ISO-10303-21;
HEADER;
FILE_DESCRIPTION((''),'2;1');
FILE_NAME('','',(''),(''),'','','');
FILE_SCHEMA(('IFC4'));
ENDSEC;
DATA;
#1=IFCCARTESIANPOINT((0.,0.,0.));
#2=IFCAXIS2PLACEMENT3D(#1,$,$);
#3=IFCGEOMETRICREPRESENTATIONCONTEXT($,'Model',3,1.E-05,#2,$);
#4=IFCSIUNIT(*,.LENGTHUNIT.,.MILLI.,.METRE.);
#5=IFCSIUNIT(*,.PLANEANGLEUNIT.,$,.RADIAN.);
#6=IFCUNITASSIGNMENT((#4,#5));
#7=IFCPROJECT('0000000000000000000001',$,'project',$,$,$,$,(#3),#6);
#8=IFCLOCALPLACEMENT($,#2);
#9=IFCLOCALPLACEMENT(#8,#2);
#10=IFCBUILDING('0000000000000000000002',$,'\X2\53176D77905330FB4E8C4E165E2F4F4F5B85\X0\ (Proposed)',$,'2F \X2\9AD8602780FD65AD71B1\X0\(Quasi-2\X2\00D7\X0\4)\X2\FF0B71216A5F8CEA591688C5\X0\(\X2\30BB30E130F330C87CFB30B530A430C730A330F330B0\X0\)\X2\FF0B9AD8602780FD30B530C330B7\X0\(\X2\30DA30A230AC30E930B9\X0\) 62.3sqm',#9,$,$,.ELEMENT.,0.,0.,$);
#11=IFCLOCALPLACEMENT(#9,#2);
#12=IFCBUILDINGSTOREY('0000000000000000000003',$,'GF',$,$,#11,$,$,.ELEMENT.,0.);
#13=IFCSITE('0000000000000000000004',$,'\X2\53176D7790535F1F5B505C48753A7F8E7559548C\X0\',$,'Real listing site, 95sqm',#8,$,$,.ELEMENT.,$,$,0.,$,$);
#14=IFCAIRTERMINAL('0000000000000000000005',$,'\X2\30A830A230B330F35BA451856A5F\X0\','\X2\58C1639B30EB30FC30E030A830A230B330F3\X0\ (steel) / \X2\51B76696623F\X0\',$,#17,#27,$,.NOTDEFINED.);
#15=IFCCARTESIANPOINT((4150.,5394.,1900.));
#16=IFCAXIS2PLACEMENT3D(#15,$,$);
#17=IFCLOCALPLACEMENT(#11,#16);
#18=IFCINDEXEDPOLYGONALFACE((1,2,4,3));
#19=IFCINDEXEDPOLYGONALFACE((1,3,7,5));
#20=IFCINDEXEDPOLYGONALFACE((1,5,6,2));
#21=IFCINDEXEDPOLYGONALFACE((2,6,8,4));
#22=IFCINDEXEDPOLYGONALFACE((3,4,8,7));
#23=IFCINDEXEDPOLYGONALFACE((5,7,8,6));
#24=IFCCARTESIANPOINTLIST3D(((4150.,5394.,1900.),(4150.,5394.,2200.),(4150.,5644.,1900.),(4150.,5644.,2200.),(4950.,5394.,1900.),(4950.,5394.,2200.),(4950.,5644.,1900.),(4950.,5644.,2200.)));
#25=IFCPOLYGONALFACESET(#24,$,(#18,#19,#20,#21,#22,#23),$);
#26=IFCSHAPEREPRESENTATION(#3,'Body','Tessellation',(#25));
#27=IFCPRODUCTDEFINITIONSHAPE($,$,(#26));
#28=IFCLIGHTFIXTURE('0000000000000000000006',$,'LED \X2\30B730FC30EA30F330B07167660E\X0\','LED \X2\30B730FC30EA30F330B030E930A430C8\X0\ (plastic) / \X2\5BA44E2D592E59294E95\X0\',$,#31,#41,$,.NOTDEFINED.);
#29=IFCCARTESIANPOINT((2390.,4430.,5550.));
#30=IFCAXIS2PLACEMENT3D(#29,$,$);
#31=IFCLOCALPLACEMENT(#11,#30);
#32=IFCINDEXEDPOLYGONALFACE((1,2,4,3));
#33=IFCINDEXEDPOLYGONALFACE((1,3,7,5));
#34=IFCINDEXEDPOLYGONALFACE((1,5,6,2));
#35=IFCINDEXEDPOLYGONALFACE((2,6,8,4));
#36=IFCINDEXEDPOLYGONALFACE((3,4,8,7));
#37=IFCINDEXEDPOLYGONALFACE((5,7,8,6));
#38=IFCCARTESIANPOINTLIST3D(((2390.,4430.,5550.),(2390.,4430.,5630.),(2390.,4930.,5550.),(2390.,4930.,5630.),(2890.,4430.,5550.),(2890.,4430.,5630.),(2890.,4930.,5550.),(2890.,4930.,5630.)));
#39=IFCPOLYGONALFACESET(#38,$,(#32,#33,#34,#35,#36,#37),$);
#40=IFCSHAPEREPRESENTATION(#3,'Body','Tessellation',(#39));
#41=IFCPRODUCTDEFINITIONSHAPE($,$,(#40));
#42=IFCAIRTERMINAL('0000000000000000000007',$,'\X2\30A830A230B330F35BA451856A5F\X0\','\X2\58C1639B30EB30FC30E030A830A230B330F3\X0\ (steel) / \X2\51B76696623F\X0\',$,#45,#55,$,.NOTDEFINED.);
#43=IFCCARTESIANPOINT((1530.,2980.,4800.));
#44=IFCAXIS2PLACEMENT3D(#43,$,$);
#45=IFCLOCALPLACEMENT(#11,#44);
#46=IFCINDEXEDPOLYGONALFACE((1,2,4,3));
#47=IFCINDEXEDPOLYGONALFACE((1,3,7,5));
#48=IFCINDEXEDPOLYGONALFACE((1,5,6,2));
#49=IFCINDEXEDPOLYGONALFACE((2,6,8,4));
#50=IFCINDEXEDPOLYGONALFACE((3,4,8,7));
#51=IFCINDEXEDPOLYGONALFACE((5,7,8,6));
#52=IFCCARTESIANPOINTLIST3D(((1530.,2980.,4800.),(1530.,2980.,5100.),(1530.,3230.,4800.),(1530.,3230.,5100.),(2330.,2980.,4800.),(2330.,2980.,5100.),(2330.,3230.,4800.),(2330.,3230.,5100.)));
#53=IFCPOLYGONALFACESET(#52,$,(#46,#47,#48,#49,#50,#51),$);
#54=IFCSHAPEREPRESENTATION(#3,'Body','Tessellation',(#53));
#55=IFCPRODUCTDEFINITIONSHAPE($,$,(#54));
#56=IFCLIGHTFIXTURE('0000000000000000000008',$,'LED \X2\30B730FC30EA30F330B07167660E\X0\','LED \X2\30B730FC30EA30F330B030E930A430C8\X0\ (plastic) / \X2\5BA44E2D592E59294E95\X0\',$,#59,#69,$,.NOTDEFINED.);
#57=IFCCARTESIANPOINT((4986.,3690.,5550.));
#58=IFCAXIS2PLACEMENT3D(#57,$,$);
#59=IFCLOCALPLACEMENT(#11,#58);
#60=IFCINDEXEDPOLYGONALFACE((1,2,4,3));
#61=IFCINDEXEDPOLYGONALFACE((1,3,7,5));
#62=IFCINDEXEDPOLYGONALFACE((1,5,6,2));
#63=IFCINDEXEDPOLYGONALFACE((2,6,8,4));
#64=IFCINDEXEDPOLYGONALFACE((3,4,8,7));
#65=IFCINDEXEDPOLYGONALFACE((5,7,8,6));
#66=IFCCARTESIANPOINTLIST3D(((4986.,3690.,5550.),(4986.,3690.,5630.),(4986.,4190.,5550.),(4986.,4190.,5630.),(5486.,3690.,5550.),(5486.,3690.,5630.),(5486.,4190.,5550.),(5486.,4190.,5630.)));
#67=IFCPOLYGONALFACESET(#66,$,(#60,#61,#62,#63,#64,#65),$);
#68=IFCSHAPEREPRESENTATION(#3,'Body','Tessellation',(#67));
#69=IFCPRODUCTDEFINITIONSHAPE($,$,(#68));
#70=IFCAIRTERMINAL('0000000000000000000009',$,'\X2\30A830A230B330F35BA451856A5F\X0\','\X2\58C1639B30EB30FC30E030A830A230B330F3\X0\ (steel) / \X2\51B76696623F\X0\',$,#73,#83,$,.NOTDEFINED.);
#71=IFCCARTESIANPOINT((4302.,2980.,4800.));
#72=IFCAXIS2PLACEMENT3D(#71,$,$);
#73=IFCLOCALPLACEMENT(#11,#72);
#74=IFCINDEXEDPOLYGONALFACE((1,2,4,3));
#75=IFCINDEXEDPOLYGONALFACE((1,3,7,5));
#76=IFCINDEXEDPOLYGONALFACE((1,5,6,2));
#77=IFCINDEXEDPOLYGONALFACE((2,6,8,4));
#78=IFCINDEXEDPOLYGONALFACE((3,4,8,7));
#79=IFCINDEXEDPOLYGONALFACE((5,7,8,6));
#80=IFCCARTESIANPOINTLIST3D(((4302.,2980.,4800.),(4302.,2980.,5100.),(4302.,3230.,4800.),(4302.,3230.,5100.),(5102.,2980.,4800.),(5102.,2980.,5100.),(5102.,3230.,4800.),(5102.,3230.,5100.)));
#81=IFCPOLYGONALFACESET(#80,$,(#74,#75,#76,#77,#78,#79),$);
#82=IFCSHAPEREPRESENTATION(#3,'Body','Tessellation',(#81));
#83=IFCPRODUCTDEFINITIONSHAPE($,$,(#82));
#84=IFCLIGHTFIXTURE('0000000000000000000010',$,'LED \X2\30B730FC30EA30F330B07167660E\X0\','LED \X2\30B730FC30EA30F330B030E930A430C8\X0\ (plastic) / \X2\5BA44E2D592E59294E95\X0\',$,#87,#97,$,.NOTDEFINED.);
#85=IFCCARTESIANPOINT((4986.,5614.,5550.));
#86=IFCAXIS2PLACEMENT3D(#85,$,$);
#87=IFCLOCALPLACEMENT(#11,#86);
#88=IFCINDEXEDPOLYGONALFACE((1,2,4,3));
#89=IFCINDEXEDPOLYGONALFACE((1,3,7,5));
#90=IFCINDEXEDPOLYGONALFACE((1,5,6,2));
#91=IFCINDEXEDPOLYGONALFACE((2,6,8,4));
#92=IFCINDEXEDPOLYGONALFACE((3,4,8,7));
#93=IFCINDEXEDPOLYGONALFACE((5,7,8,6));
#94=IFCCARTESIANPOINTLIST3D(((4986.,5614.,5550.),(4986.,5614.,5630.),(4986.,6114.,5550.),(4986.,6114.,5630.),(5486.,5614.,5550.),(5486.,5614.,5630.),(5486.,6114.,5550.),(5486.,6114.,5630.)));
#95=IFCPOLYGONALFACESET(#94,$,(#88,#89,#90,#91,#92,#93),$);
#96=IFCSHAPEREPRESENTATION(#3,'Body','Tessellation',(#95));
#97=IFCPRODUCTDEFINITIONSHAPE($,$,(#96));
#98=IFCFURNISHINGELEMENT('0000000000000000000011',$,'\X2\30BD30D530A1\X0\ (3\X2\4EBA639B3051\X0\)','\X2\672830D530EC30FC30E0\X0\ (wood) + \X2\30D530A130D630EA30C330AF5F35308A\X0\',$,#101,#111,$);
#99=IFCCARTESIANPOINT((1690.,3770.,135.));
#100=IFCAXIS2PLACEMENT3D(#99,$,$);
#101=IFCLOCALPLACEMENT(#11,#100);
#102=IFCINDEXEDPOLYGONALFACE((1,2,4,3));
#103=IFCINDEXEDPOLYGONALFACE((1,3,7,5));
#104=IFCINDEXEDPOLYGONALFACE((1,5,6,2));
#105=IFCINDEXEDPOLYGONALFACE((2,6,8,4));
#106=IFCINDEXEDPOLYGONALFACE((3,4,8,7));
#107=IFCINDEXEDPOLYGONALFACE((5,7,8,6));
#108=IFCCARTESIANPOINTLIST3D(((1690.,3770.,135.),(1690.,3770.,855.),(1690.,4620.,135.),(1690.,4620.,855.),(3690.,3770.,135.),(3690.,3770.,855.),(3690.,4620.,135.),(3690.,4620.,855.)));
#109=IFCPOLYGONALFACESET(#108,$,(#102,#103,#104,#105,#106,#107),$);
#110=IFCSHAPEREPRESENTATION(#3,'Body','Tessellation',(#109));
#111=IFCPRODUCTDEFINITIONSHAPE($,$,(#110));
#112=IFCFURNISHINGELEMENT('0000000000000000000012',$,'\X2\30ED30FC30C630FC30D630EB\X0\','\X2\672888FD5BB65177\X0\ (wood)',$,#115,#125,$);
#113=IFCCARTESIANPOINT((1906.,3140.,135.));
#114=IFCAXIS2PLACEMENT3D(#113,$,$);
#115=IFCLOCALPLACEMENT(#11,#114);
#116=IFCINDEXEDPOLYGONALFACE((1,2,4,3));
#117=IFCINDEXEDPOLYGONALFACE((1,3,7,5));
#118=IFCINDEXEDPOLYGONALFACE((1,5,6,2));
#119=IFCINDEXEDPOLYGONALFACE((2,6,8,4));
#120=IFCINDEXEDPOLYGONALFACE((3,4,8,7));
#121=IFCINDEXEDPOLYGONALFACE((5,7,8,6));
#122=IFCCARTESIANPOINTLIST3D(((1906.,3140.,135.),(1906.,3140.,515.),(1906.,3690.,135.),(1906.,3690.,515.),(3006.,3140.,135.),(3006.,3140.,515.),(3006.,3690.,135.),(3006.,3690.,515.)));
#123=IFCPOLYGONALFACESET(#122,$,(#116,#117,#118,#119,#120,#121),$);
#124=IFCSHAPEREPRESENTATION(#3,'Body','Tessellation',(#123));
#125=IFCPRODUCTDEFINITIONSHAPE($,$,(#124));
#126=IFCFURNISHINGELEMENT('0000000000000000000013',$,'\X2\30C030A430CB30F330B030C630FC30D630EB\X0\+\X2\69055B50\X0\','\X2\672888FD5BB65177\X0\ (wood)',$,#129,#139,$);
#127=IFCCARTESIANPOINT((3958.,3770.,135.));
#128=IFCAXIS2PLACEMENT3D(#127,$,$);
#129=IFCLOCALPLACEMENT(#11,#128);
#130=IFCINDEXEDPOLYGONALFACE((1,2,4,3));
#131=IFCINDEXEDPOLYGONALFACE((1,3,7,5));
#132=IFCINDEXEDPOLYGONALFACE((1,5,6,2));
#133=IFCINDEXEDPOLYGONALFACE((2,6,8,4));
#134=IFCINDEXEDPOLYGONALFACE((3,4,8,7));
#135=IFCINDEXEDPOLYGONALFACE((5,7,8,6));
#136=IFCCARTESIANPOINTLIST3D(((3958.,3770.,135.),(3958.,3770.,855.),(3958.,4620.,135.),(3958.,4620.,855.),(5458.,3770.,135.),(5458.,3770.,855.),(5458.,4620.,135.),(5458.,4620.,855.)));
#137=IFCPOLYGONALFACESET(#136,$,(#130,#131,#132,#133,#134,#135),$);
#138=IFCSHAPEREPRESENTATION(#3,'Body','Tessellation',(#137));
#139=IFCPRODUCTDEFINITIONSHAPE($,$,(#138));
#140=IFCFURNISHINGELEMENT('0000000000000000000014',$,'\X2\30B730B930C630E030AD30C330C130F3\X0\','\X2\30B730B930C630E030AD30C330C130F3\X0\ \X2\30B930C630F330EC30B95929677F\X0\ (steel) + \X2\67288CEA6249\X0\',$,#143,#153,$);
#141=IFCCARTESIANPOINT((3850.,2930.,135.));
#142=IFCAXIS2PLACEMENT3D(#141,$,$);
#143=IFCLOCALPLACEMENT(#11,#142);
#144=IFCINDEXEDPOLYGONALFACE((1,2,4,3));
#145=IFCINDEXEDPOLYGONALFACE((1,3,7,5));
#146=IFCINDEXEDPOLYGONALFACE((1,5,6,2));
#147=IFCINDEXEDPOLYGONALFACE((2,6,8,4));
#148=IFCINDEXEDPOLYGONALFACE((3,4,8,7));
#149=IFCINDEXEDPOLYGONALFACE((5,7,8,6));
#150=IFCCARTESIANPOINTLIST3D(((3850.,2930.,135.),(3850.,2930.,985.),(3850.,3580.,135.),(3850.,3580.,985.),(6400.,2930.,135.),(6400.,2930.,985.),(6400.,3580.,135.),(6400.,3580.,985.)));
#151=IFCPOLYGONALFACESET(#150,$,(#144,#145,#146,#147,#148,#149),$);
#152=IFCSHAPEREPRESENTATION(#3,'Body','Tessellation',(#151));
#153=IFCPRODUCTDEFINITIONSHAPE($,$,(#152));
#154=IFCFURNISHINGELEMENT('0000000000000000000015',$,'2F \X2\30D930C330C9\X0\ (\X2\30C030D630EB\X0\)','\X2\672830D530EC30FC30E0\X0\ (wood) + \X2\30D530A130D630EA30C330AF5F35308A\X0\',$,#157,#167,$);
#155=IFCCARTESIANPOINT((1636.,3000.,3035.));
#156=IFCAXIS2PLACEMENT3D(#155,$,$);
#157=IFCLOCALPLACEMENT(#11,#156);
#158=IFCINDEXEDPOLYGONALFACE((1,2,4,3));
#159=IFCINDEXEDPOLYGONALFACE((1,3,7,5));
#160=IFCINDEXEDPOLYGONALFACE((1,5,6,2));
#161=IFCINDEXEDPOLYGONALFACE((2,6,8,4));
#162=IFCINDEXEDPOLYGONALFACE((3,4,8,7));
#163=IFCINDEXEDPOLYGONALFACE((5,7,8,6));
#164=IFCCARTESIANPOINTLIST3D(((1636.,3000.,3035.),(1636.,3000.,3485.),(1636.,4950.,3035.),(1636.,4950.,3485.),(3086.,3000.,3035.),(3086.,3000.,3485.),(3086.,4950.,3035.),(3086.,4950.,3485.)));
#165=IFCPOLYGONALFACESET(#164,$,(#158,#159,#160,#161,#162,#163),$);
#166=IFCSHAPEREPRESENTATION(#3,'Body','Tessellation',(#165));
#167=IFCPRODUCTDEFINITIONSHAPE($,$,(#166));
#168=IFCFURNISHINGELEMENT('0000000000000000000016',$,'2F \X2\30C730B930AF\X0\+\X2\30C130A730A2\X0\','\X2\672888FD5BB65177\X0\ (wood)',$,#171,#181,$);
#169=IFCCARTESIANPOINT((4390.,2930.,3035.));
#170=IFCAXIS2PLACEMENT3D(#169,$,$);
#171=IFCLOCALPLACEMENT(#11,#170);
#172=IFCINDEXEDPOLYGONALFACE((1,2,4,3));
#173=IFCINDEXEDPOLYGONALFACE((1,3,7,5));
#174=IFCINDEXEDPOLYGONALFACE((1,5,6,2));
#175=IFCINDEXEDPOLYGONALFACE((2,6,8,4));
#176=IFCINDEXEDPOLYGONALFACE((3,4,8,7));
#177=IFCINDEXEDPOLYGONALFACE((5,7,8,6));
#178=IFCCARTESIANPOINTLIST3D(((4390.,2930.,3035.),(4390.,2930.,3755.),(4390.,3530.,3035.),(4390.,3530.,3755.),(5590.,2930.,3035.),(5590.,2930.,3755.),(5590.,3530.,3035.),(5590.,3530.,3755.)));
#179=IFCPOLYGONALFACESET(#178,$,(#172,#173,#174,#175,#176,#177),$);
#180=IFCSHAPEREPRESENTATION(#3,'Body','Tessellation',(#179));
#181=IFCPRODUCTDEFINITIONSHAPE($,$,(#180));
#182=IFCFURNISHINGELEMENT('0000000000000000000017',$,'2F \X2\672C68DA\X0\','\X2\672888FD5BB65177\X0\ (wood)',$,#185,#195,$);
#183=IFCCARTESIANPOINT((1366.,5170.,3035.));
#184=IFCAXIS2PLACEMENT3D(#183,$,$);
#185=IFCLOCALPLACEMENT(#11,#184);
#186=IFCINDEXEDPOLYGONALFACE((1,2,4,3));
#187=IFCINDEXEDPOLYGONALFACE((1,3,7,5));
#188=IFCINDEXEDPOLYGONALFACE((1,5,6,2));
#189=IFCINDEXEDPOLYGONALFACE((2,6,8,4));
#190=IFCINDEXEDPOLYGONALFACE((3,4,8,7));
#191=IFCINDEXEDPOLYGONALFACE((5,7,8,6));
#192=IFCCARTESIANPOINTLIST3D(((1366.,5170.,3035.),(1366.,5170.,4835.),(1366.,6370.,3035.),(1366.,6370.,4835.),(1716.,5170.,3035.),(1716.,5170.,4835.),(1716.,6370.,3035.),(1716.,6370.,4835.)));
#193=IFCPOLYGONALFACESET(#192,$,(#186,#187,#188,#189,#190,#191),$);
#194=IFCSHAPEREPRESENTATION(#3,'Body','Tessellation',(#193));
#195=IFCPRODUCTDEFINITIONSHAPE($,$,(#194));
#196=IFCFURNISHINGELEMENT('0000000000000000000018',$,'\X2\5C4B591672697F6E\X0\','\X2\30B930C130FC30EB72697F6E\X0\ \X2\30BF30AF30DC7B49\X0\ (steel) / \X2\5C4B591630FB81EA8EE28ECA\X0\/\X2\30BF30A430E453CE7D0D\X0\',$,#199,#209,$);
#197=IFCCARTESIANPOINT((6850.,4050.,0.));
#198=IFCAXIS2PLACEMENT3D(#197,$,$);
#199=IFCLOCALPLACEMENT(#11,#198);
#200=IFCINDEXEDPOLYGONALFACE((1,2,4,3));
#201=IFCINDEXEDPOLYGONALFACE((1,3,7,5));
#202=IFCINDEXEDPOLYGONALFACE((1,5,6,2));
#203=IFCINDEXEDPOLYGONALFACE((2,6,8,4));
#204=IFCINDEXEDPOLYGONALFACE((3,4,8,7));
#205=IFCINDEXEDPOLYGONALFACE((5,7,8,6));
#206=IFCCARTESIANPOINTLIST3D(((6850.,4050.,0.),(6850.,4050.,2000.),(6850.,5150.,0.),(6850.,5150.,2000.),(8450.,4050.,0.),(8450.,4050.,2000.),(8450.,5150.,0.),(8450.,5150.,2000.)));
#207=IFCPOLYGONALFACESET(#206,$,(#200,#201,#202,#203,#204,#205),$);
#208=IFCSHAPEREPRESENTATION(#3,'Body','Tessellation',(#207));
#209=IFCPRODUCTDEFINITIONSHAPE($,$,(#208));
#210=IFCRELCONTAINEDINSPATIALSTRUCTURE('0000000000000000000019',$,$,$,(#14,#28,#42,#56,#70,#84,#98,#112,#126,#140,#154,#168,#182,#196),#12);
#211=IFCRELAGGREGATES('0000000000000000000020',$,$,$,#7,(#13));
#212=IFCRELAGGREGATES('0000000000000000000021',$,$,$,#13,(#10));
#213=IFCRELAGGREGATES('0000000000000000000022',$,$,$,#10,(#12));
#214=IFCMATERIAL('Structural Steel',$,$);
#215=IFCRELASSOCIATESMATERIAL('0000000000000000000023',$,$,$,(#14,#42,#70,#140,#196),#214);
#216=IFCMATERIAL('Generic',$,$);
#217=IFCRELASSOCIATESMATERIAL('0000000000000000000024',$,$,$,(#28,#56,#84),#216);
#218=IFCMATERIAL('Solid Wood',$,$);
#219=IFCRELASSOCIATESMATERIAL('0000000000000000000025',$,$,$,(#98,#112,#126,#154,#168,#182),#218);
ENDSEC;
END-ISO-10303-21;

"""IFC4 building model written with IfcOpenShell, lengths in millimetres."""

from ifc_helpers import new_model, si_unit, frame, frame_2d, origin, place, context, project, spatial, rectangle, extrude, material, element, save


model = new_model("IFC4")

# Units and contexts
model_context = context("Model", 3, precision=1e-05, world=origin())
ifc_project = project(units=[si_unit("LENGTHUNIT", "METRE", prefix="MILLI"), si_unit("PLANEANGLEUNIT", "RADIAN")], contexts=[model_context])

# Site, building, storey
site_placement = place(None, origin())
site = spatial("IfcSite", under=ifc_project, at=site_placement, Name="北海道弟子屈町美留和", ObjectType="Real listing site, 95sqm", CompositionType="ELEMENT", RefElevation=0.0)
building_placement = place(site_placement, origin())
building = spatial("IfcBuilding", under=site, at=building_placement, Name="北海道・二世帯住宅 (Proposed)", ObjectType="2F 高性能断熱(Quasi-2×4)＋無機質外装(セメント系サイディング)＋高性能サッシ(ペアガラス) 62.3sqm", CompositionType="ELEMENT", ElevationOfRefHeight=0.0, ElevationOfTerrain=0.0)
storey_placement = place(building_placement, origin())
storey = spatial("IfcBuildingStorey", under=building, at=storey_placement, Name="GF", CompositionType="ELEMENT", Elevation=0.0)

# Shared definitions
ifc_material_1 = material(Name="Solid Wood")

# Shared definitions
ifc_material_2 = material(Name="Structural Steel")

# Shared definitions
ifc_material_3 = material(Name="Generic")

# Air terminal
air_terminal_1_placement = place(storey_placement, frame((4150.0, 5394.0, 1900.0)))
element("IfcAirTerminal", 1, at=air_terminal_1_placement, inside=storey, material=ifc_material_2, Name="エアコン室内機", Description="壁掛ルームエアコン (steel) / 冷暖房", PredefinedType="NOTDEFINED", context=model_context, shape_type="SweptSolid", body=[
    extrude(rectangle(XDim=800.0, YDim=250.0, at=frame_2d((400.0, 125.0))), frame((4150.0, 5394.0, 1900.0)), (0.0, 0.0, 1.0), 300.0),
])

# Light fixture
light_fixture_1_placement = place(storey_placement, frame((2390.0, 4430.0, 5550.0)))
element("IfcLightFixture", 2, at=light_fixture_1_placement, inside=storey, material=ifc_material_3, Name="LED シーリング照明", Description="LED シーリングライト (plastic) / 室中央天井", PredefinedType="NOTDEFINED", context=model_context, shape_type="SweptSolid", body=[
    extrude(rectangle(XDim=500.0, YDim=500.0, at=frame_2d((250.0, 250.0))), frame((2390.0, 4430.0, 5550.0)), (0.0, 0.0, 1.0), 80.0),
])

# Air terminal
air_terminal_2_placement = place(storey_placement, frame((1530.0, 2980.0, 4800.0)))
element("IfcAirTerminal", 3, at=air_terminal_2_placement, inside=storey, material=ifc_material_2, Name="エアコン室内機", Description="壁掛ルームエアコン (steel) / 冷暖房", PredefinedType="NOTDEFINED", context=model_context, shape_type="SweptSolid", body=[
    extrude(rectangle(XDim=800.0, YDim=250.0, at=frame_2d((400.0, 125.0))), frame((1530.0, 2980.0, 4800.0)), (0.0, 0.0, 1.0), 300.0),
])

# Light fixture
light_fixture_2_placement = place(storey_placement, frame((4986.0, 3690.0, 5550.0)))
element("IfcLightFixture", 4, at=light_fixture_2_placement, inside=storey, material=ifc_material_3, Name="LED シーリング照明", Description="LED シーリングライト (plastic) / 室中央天井", PredefinedType="NOTDEFINED", context=model_context, shape_type="SweptSolid", body=[
    extrude(rectangle(XDim=500.0, YDim=500.0, at=frame_2d((250.0, 250.0))), frame((4986.0, 3690.0, 5550.0)), (0.0, 0.0, 1.0), 80.0),
])

# Air terminal
air_terminal_3_placement = place(storey_placement, frame((4302.0, 2980.0, 4800.0)))
element("IfcAirTerminal", 5, at=air_terminal_3_placement, inside=storey, material=ifc_material_2, Name="エアコン室内機", Description="壁掛ルームエアコン (steel) / 冷暖房", PredefinedType="NOTDEFINED", context=model_context, shape_type="SweptSolid", body=[
    extrude(rectangle(XDim=800.0, YDim=250.0, at=frame_2d((400.0, 125.0))), frame((4302.0, 2980.0, 4800.0)), (0.0, 0.0, 1.0), 300.0),
])

# Light fixture
light_fixture_3_placement = place(storey_placement, frame((4986.0, 5614.0, 5550.0)))
element("IfcLightFixture", 6, at=light_fixture_3_placement, inside=storey, material=ifc_material_3, Name="LED シーリング照明", Description="LED シーリングライト (plastic) / 室中央天井", PredefinedType="NOTDEFINED", context=model_context, shape_type="SweptSolid", body=[
    extrude(rectangle(XDim=500.0, YDim=500.0, at=frame_2d((250.0, 250.0))), frame((4986.0, 5614.0, 5550.0)), (0.0, 0.0, 1.0), 80.0),
])

# Furnishing elements
furnishing_1_placement = place(storey_placement, frame((1690.0, 3770.0, 135.0)))
element("IfcFurnishingElement", 7, at=furnishing_1_placement, inside=storey, material=ifc_material_1, Name="ソファ (3人掛け)", Description="木フレーム (wood) + ファブリック張り", context=model_context, shape_type="SweptSolid", body=[
    extrude(rectangle(XDim=2000.0, YDim=850.0, at=frame_2d((1000.0, 425.0))), frame((1690.0, 3770.0, 135.0)), (0.0, 0.0, 1.0), 720.0),
])
furnishing_2_placement = place(storey_placement, frame((1906.0, 3140.0, 135.0)))
element("IfcFurnishingElement", 8, at=furnishing_2_placement, inside=storey, material=ifc_material_1, Name="ローテーブル", Description="木製家具 (wood)", context=model_context, shape_type="SweptSolid", body=[
    extrude(rectangle(XDim=1100.0, YDim=550.0, at=frame_2d((550.0, 275.0))), frame((1906.0, 3140.0, 135.0)), (0.0, 0.0, 1.0), 380.0),
])
furnishing_3_placement = place(storey_placement, frame((3958.0, 3770.0, 135.0)))
element("IfcFurnishingElement", 9, at=furnishing_3_placement, inside=storey, material=ifc_material_1, Name="ダイニングテーブル+椅子", Description="木製家具 (wood)", context=model_context, shape_type="SweptSolid", body=[
    extrude(rectangle(XDim=1500.0, YDim=850.0, at=frame_2d((750.0, 425.0))), frame((3958.0, 3770.0, 135.0)), (0.0, 0.0, 1.0), 720.0),
])
furnishing_4_placement = place(storey_placement, frame((3850.0, 2930.0, 135.0)))
element("IfcFurnishingElement", 10, at=furnishing_4_placement, inside=storey, material=ifc_material_2, Name="システムキッチン", Description="システムキッチン ステンレス天板 (steel) + 木質扉", context=model_context, shape_type="SweptSolid", body=[
    extrude(rectangle(XDim=2550.0, YDim=650.0, at=frame_2d((1275.0, 325.0))), frame((3850.0, 2930.0, 135.0)), (0.0, 0.0, 1.0), 850.0),
])
furnishing_5_placement = place(storey_placement, frame((1636.0, 3000.0, 3035.0)))
element("IfcFurnishingElement", 11, at=furnishing_5_placement, inside=storey, material=ifc_material_1, Name="2F ベッド (ダブル)", Description="木フレーム (wood) + ファブリック張り", context=model_context, shape_type="SweptSolid", body=[
    extrude(rectangle(XDim=1450.0, YDim=1950.0, at=frame_2d((725.0, 975.0))), frame((1636.0, 3000.0, 3035.0)), (0.0, 0.0, 1.0), 450.0),
])
furnishing_6_placement = place(storey_placement, frame((4390.0, 2930.0, 3035.0)))
element("IfcFurnishingElement", 12, at=furnishing_6_placement, inside=storey, material=ifc_material_1, Name="2F デスク+チェア", Description="木製家具 (wood)", context=model_context, shape_type="SweptSolid", body=[
    extrude(rectangle(XDim=1200.0, YDim=600.0, at=frame_2d((600.0, 300.0))), frame((4390.0, 2930.0, 3035.0)), (0.0, 0.0, 1.0), 720.0),
])
furnishing_7_placement = place(storey_placement, frame((1366.0, 5170.0, 3035.0)))
element("IfcFurnishingElement", 13, at=furnishing_7_placement, inside=storey, material=ifc_material_1, Name="2F 本棚", Description="木製家具 (wood)", context=model_context, shape_type="SweptSolid", body=[
    extrude(rectangle(XDim=350.0, YDim=1200.0, at=frame_2d((175.0, 600.0))), frame((1366.0, 5170.0, 3035.0)), (0.0, 0.0, 1.0), 1800.0),
])
furnishing_8_placement = place(storey_placement, frame((6850.0, 4050.0, 0.0)))
element("IfcFurnishingElement", 14, at=furnishing_8_placement, inside=storey, material=ifc_material_2, Name="屋外物置", Description="スチール物置 タクボ等 (steel) / 屋外・自転車/タイヤ収納", context=model_context, shape_type="SweptSolid", body=[
    extrude(rectangle(XDim=1600.0, YDim=1100.0, at=frame_2d((800.0, 550.0))), frame((6850.0, 4050.0, 0.0)), (0.0, 0.0, 1.0), 2000.0),
])

save(model, "model.ifc")
